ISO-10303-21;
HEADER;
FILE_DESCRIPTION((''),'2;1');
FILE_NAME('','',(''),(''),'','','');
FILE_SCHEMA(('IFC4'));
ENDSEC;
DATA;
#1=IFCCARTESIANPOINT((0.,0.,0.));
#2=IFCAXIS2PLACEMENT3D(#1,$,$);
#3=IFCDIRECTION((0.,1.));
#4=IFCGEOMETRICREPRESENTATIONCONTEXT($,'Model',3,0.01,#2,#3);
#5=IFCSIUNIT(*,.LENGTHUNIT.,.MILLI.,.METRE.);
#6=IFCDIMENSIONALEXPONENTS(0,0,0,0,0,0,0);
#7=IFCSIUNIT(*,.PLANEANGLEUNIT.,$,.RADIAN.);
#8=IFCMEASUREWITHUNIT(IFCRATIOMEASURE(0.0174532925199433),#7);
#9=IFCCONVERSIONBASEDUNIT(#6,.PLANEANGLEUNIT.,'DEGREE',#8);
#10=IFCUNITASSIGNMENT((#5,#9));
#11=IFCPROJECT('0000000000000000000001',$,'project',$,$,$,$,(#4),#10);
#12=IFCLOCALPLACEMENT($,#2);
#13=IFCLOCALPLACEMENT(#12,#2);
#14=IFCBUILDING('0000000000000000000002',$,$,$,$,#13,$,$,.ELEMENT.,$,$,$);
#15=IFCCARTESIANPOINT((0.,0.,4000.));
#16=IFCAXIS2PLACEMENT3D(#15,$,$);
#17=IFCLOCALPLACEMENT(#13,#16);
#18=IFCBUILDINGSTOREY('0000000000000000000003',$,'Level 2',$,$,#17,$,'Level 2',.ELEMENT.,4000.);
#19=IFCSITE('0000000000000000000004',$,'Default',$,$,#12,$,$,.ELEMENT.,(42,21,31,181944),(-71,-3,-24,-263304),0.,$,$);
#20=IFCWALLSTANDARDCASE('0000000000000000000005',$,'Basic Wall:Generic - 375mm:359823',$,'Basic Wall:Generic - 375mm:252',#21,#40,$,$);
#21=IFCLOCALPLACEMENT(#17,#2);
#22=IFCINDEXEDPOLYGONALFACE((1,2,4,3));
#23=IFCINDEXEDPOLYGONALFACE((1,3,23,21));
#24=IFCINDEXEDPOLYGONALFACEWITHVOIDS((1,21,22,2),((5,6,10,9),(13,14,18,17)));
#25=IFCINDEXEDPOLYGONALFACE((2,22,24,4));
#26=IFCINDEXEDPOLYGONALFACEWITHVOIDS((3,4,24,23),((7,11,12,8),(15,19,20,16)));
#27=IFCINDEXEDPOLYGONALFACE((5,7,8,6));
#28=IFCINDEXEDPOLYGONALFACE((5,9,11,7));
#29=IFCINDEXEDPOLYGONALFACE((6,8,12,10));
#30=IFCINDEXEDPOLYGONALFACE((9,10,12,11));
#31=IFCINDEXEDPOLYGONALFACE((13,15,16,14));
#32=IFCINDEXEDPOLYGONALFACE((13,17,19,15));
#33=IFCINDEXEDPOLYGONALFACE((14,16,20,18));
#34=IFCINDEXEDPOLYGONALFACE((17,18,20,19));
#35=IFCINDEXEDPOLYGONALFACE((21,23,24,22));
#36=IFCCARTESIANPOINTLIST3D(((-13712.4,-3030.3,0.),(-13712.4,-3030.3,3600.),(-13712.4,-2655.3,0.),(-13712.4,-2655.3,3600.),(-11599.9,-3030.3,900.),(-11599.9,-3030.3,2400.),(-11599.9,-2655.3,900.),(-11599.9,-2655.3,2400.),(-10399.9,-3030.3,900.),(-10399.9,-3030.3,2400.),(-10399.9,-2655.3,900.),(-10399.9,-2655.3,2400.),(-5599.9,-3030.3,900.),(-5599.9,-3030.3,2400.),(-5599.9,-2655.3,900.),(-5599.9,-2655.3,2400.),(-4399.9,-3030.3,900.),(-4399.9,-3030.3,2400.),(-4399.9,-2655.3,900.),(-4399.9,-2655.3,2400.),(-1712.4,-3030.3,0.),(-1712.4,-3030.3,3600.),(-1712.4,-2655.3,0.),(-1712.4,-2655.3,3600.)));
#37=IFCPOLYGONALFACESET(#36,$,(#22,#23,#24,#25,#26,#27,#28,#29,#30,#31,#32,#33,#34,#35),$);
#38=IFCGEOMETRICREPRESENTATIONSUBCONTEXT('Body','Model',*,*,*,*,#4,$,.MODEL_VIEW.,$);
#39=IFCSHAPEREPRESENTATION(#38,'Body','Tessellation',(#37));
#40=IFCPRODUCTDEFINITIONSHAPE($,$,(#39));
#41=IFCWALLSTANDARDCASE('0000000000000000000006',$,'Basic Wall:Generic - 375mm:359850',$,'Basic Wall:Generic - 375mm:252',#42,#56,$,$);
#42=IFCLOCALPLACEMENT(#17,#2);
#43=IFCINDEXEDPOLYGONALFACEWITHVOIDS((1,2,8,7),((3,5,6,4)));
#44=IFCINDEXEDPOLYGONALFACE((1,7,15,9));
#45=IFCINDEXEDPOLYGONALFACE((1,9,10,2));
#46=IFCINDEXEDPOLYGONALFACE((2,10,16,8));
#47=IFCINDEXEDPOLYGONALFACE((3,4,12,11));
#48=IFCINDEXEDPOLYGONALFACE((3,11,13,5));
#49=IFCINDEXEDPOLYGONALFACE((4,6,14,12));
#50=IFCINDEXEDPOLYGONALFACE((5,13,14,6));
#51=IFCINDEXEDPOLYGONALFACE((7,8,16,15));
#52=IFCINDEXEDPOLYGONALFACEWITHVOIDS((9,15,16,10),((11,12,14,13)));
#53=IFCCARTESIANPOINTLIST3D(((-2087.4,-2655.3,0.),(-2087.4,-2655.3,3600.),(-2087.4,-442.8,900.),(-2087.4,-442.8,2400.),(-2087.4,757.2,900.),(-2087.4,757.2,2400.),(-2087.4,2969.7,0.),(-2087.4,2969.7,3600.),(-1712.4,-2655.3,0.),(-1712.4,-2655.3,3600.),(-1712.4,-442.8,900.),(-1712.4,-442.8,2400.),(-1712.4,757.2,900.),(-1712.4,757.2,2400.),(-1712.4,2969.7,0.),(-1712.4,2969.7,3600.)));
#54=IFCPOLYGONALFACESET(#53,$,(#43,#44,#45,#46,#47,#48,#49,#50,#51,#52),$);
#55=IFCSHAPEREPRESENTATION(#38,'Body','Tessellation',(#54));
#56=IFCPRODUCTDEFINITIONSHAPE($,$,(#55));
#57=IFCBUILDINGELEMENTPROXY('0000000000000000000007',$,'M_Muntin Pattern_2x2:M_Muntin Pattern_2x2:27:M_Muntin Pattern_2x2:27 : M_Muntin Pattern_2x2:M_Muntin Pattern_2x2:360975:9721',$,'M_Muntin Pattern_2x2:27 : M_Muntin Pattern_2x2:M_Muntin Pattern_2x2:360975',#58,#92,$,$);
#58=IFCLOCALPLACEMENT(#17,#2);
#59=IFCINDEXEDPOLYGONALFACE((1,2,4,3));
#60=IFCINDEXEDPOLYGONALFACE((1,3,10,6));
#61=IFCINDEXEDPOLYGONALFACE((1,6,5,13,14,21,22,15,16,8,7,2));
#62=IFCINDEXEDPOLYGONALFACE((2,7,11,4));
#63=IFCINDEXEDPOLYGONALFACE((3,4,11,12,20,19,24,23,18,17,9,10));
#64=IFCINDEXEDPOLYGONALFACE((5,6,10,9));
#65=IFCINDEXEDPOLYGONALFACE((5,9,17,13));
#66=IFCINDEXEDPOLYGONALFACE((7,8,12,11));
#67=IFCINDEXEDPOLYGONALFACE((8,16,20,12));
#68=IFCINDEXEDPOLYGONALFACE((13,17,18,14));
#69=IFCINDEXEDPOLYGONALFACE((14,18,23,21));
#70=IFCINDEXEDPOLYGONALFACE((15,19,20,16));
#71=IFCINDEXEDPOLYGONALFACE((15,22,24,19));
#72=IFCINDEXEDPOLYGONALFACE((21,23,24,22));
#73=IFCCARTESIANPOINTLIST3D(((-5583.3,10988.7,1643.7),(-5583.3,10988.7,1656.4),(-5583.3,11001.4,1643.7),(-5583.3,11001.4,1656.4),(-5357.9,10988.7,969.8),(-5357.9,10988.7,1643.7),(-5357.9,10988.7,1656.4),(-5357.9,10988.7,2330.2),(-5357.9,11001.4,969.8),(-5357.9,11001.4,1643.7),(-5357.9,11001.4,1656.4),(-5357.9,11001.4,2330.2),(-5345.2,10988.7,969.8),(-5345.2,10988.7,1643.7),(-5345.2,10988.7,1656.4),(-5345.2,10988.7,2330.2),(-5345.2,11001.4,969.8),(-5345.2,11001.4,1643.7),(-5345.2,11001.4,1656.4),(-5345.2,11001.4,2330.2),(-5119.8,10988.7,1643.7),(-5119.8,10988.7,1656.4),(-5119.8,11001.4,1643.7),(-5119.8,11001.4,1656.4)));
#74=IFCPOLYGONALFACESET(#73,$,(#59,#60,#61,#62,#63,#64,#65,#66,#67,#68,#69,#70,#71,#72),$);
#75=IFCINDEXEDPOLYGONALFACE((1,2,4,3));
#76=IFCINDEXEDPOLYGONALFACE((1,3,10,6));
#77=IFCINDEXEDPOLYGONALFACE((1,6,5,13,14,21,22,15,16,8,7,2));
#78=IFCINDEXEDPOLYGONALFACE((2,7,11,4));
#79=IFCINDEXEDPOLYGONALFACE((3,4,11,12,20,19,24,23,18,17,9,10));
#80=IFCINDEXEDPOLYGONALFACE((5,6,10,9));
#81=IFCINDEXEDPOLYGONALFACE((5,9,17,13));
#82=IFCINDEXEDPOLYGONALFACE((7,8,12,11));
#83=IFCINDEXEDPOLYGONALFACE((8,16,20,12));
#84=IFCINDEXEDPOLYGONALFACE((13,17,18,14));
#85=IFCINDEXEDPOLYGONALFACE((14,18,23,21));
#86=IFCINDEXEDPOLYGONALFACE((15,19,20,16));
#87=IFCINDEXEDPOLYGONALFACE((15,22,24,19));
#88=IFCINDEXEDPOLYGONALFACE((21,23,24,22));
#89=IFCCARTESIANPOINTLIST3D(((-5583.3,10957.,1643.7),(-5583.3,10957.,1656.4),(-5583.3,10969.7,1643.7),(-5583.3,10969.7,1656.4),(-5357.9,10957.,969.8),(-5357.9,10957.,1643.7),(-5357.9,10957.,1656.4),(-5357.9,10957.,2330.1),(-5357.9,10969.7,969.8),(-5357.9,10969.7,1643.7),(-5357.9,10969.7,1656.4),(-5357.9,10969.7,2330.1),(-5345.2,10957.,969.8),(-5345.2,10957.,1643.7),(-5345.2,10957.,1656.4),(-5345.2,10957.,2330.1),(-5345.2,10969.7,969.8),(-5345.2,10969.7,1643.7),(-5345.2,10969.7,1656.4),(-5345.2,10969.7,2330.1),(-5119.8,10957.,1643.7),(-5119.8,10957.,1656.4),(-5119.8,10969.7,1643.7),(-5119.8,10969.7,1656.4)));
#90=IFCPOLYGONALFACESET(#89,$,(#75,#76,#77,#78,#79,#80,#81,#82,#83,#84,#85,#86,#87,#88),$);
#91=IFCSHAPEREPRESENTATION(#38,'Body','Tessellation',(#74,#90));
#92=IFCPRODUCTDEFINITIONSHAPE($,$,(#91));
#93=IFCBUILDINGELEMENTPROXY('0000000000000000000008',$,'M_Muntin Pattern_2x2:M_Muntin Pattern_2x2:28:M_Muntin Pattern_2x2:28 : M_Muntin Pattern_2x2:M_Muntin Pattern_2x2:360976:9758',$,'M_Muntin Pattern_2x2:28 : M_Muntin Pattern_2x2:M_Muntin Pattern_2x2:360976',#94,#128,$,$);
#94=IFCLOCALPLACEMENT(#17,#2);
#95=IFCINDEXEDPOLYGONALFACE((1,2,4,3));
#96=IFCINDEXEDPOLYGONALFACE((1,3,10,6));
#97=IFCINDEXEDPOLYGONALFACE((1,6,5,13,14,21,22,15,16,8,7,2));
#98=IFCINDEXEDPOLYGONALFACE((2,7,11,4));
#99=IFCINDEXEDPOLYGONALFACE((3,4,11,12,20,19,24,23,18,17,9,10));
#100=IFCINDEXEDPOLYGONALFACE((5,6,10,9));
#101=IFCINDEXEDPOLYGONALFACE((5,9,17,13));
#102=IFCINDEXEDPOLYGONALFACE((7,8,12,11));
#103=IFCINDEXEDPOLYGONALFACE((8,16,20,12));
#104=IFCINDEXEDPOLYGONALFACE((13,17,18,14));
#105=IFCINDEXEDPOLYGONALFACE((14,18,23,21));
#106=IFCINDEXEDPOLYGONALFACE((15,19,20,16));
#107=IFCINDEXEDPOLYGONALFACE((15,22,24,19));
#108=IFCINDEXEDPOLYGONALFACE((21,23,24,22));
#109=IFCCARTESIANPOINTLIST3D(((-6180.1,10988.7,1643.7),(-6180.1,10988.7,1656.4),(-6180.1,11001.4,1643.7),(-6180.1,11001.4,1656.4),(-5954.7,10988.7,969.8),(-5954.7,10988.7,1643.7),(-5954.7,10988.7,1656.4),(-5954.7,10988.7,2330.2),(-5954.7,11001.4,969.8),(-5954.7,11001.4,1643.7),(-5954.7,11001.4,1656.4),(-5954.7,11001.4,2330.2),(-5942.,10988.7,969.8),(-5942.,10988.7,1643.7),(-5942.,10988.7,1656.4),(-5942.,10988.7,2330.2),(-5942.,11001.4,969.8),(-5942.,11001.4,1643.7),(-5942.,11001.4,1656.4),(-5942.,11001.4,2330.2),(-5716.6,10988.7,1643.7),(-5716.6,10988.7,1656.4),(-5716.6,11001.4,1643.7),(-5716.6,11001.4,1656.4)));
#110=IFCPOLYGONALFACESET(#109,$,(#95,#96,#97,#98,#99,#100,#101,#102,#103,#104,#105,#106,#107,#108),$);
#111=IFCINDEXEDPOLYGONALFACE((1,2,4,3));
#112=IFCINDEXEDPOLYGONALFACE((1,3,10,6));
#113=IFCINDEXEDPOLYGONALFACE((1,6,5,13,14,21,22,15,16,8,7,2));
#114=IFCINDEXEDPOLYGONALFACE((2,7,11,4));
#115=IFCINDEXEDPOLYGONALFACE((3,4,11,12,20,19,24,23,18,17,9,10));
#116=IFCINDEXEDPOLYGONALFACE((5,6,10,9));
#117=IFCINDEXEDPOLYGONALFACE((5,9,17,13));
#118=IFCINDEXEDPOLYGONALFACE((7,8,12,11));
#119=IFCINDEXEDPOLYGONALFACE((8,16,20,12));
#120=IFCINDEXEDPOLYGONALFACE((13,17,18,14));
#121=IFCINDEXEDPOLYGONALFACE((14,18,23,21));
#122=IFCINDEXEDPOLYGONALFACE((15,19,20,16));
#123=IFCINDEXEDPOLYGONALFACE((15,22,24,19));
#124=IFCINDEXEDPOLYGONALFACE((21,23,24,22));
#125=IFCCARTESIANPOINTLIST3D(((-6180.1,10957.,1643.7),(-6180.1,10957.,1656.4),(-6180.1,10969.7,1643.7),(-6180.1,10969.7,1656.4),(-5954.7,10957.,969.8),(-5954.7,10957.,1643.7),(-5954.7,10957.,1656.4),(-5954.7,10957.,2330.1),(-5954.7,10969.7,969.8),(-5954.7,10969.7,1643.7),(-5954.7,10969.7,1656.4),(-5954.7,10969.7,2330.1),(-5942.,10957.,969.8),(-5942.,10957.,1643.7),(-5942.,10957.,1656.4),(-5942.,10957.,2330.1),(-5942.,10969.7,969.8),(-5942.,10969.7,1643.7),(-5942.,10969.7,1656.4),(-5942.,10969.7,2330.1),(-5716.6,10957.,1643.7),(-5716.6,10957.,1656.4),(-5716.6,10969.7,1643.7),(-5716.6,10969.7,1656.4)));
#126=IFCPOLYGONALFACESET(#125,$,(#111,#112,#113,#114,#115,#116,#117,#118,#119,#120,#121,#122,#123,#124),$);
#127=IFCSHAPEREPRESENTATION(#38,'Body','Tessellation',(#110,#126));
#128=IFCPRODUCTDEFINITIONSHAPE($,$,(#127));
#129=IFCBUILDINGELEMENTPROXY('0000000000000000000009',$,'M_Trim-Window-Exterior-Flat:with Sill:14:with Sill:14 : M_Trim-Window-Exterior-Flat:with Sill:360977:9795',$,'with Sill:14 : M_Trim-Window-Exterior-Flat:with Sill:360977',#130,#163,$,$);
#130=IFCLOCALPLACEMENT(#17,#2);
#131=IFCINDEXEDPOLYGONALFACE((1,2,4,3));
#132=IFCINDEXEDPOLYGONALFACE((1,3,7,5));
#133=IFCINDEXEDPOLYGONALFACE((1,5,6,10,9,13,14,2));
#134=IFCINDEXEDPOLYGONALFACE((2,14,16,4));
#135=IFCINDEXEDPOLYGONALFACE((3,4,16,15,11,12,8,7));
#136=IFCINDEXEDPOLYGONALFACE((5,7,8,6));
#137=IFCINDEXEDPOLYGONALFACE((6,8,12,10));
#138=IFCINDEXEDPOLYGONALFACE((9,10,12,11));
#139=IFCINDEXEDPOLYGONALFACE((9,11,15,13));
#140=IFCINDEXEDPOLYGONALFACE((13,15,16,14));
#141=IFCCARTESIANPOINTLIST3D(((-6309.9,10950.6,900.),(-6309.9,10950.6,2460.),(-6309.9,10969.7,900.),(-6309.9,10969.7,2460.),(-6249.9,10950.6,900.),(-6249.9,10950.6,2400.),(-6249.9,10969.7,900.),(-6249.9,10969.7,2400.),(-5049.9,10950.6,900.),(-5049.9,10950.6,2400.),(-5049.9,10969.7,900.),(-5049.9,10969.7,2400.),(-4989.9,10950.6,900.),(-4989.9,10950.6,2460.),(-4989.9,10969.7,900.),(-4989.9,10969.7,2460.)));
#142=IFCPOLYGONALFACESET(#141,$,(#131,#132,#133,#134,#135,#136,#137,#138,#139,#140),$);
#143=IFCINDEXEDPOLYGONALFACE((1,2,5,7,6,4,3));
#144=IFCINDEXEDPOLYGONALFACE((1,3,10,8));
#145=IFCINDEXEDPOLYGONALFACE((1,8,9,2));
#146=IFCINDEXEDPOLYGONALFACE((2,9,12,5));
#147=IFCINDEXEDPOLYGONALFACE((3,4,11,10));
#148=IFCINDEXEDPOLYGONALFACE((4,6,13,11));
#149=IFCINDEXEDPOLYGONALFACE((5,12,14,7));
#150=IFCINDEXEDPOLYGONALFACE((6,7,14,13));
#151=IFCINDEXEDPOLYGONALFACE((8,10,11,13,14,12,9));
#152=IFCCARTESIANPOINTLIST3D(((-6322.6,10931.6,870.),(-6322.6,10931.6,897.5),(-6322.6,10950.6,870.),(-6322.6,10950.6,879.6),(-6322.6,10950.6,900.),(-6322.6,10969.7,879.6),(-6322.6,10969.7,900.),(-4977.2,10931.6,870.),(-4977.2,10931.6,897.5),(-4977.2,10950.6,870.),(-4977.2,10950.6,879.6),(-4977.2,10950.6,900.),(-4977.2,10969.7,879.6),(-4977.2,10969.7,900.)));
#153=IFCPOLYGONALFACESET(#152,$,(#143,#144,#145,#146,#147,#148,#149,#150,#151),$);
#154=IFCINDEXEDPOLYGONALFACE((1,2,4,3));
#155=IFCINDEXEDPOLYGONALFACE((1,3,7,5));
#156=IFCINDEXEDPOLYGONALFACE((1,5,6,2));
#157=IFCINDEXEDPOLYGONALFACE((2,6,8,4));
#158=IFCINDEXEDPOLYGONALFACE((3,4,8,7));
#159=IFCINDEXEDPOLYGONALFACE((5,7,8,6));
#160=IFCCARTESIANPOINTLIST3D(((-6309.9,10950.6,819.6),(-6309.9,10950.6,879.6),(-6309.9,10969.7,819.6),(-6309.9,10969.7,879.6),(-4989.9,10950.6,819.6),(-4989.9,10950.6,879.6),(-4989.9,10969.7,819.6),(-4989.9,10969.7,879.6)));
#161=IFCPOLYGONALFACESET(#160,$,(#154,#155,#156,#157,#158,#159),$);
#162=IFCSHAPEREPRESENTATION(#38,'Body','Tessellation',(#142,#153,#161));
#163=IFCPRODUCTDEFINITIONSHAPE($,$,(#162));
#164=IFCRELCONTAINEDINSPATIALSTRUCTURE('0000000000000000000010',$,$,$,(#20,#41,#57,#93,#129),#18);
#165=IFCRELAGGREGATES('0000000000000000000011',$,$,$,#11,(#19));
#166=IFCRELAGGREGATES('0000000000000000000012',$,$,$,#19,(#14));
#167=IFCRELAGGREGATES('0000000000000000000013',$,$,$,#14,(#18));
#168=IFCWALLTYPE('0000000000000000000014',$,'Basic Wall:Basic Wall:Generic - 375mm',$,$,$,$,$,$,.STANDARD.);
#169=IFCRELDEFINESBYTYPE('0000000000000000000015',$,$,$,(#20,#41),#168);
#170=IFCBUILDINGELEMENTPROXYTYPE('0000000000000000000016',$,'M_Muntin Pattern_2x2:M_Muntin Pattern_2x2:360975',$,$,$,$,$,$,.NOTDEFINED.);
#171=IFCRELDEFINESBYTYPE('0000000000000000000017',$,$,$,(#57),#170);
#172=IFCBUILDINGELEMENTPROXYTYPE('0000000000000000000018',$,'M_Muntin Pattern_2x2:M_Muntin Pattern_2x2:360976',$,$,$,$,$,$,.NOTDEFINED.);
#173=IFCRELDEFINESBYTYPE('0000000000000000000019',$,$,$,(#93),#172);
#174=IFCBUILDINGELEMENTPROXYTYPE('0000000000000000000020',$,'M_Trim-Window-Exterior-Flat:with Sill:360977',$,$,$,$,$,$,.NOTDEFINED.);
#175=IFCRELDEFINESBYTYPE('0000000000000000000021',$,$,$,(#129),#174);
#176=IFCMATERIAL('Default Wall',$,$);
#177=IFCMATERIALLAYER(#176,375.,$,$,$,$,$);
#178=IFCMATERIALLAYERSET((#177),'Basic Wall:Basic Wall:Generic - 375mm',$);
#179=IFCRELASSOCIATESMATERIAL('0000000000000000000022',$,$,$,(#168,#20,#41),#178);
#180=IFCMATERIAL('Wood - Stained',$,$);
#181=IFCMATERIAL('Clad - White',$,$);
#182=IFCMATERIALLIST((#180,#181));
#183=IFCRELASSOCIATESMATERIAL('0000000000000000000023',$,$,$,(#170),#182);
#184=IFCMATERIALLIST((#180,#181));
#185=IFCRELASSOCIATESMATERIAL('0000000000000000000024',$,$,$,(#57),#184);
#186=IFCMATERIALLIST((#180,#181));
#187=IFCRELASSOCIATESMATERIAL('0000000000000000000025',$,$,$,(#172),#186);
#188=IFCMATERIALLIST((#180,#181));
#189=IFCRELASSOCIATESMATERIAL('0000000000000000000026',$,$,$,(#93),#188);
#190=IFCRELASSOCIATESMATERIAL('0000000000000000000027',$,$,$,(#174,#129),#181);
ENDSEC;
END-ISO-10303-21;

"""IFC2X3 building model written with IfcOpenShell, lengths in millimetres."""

from ifc_helpers import new_model, entity, si_unit, converted_unit, direction, frame, frame_2d, origin, place, context, subcontext, project, spatial, polyline, rectangle, outline, extrude, source, transform, mapped, material, material_list, layer, layer_set, layer_usage, type_object, type_shapes, element, save


model = new_model("IFC2X3")

# Units and contexts
model_context = context("Model", 3, precision=0.01, world=origin(), true_north=direction((0.0, 1.0)))
body_context = subcontext(model_context, "Body", "Model", "MODEL_VIEW")
ifc_project = project(units=[si_unit("LENGTHUNIT", "METRE", prefix="MILLI"), converted_unit("PLANEANGLEUNIT", "DEGREE", entity("IfcRatioMeasure", 0.0174532925199433), si_unit("PLANEANGLEUNIT", "RADIAN"), dimensions=[0, 0, 0, 0, 0, 0, 0])], contexts=[model_context])

# Site, building, storey
site_placement = place(None, origin())
site = spatial("IfcSite", under=ifc_project, at=site_placement, Name="Default", CompositionType="ELEMENT", RefLatitude=(42, 21, 31, 181944), RefLongitude=(-71, -3, -24, -263304), RefElevation=0.0)
building_placement = place(site_placement, origin())
building = spatial("IfcBuilding", under=site, at=building_placement, CompositionType="ELEMENT")
storey_placement = place(building_placement, frame((0.0, 0.0, 4000.0)))
storey = spatial("IfcBuildingStorey", under=building, at=storey_placement, Name="Level 2", LongName="Level 2", CompositionType="ELEMENT", Elevation=4000.0)

# Wall, openings
ifc_material_1 = material(Name="Default Wall")
ifc_layer_1 = layer(ifc_material_1, 375.0)
ifc_layer_set_1 = layer_set([ifc_layer_1], Name="Basic Wall:Basic Wall:Generic - 375mm")
ifc_layer_usage_1 = layer_usage(ifc_layer_set_1, "AXIS2", "NEGATIVE", 187.5)
wall_type = type_object("IfcWallType", Name="Basic Wall:Basic Wall:Generic - 375mm", PredefinedType="STANDARD", material=ifc_layer_set_1)
wall_1_placement = place(storey_placement, frame((-13712.4, -2842.8, 0.0)))
wall_1 = element("IfcWallStandardCase", 1, at=wall_1_placement, inside=storey, type_object=wall_type, material=ifc_layer_usage_1, Name="Basic Wall:Generic - 375mm:359823", ObjectType="Basic Wall:Generic - 375mm:252", context=body_context, shape_type="SweptSolid", body=[
    extrude(rectangle(XDim=12000.0, YDim=375.0, at=frame_2d((6000.0, 0.0), x_axis=(-1.0, 0.0))), origin(), (0.0, 0.0, 1.0), 3600.0),
])
opening_1_placement = place(wall_1_placement, frame((13712.4, 2842.8, 0.0)))
element("IfcOpeningElement", 2, at=opening_1_placement, cuts=wall_1, ObjectType="Opening", context=body_context, shape_type="SweptSolid", body=[
    extrude(rectangle(XDim=1500.0, YDim=1200.0, at=frame_2d((0.0, 0.0), x_axis=(0.0, 1.0))), frame((-10999.9, -3034.1, 1650.0), z_axis=(0.0, 1.0, 0.0), x_axis=(-1.0, 0.0, 0.0)), (0.0, 0.0, 1.0), 382.5),
])
opening_2_placement = place(wall_1_placement, frame((13712.4, 2842.8, 0.0)))
element("IfcOpeningElement", 3, at=opening_2_placement, cuts=wall_1, ObjectType="Opening", context=body_context, shape_type="SweptSolid", body=[
    extrude(rectangle(XDim=1500.0, YDim=1200.0, at=frame_2d((0.0, 0.0), x_axis=(0.0, 1.0))), frame((-4999.9, -3034.1, 1650.0), z_axis=(0.0, 1.0, 0.0), x_axis=(-1.0, 0.0, 0.0)), (0.0, 0.0, 1.0), 382.5),
])

# Wall, opening
ifc_layer_usage_2 = layer_usage(ifc_layer_set_1, "AXIS2", "NEGATIVE", 187.5)
wall_2_placement = place(storey_placement, frame((-1899.9, -2655.3, 0.0), z_axis=(0.0, 0.0, 1.0), x_axis=(0.0, 1.0, 0.0)))
wall_2 = element("IfcWallStandardCase", 4, at=wall_2_placement, inside=storey, type_object=wall_type, material=ifc_layer_usage_2, Name="Basic Wall:Generic - 375mm:359850", ObjectType="Basic Wall:Generic - 375mm:252", context=body_context, shape_type="SweptSolid", body=[
    extrude(rectangle(XDim=5625.0, YDim=375.0, at=frame_2d((2812.5, 0.0), x_axis=(-1.0, 0.0))), origin(), (0.0, 0.0, 1.0), 3600.0),
])
opening_3_placement = place(wall_2_placement, frame((2655.3, -1899.9, 0.0), z_axis=(0.0, 0.0, 1.0), x_axis=(0.0, -1.0, 0.0)))
element("IfcOpeningElement", 5, at=opening_3_placement, cuts=wall_2, ObjectType="Opening", context=body_context, shape_type="SweptSolid", body=[
    extrude(rectangle(XDim=1500.0, YDim=1200.0, at=frame_2d((0.0, 0.0), x_axis=(0.0, 1.0))), frame((-1708.7, 157.2, 1650.0), z_axis=(-1.0, 0.0, 0.0), x_axis=(0.0, -1.0, 0.0)), (0.0, 0.0, 1.0), 382.5),
])

# Building element proxies
ifc_material_2 = material(Name="Wood - Stained")
ifc_material_3 = material(Name="Clad - White")
ifc_material_list_1 = material_list([ifc_material_2, ifc_material_3])
ifc_material_list_2 = material_list([ifc_material_2, ifc_material_3])
building_element_proxy_type_1 = type_object("IfcBuildingElementProxyType", Name="M_Muntin Pattern_2x2:M_Muntin Pattern_2x2:360975", PredefinedType="NOTDEFINED", material=ifc_material_list_2)
shared_shape_1 = source(origin(), body_context, "Body", "SweptSolid", [
    extrude(outline(polyline([(-680.2, 6.4), (-680.2, -6.3), (-6.4, -6.3), (-6.4, -231.7), (6.3, -231.7), (6.3, -6.3), (680.2, -6.3), (680.2, 6.4), (6.3, 6.4), (6.3, 231.7), (-6.4, 231.7), (-6.4, 6.4), (-680.2, 6.4)])), frame((-5351.5, 10988.7, 5650.0), z_axis=(0.0, -1.0, 0.0), x_axis=(0.0, 0.0, -1.0)), (0.0, 0.0, -1.0), 12.7),
    extrude(outline(polyline([(-680.1, 6.4), (-680.1, -6.3), (-6.4, -6.3), (-6.4, -231.7), (6.3, -231.7), (6.3, -6.3), (680.2, -6.3), (680.2, 6.4), (6.3, 6.4), (6.3, 231.7), (-6.4, 231.7), (-6.4, 6.4), (-680.1, 6.4)])), frame((-5351.5, 10957.0, 5650.0), z_axis=(0.0, -1.0, 0.0), x_axis=(0.0, 0.0, -1.0)), (0.0, 0.0, -1.0), 12.7),
])
type_shapes(building_element_proxy_type_1, [shared_shape_1])
proxy_1_placement = place(storey_placement, frame((0.0, 0.0, -4000.0)))
element("IfcBuildingElementProxy", 6, at=proxy_1_placement, inside=storey, type_object=building_element_proxy_type_1, material=ifc_material_list_1, Name="M_Muntin Pattern_2x2:M_Muntin Pattern_2x2:27:M_Muntin Pattern_2x2:27 : M_Muntin Pattern_2x2:M_Muntin Pattern_2x2:360975:9721", ObjectType="M_Muntin Pattern_2x2:27 : M_Muntin Pattern_2x2:M_Muntin Pattern_2x2:360975", context=body_context, shape_type="MappedRepresentation", body=[
    mapped(shared_shape_1, transform((0.0, 0.0, 0.0), scale=1.0)),
])
ifc_material_list_3 = material_list([ifc_material_2, ifc_material_3])
ifc_material_list_4 = material_list([ifc_material_2, ifc_material_3])
building_element_proxy_type_2 = type_object("IfcBuildingElementProxyType", Name="M_Muntin Pattern_2x2:M_Muntin Pattern_2x2:360976", PredefinedType="NOTDEFINED", material=ifc_material_list_4)
shared_shape_2 = source(origin(), body_context, "Body", "SweptSolid", [
    extrude(outline(polyline([(-6.4, -680.1), (6.3, -680.1), (6.3, -6.4), (231.7, -6.4), (231.7, 6.3), (6.3, 6.3), (6.3, 680.2), (-6.4, 680.2), (-6.4, 6.3), (-231.7, 6.3), (-231.7, -6.4), (-6.4, -6.4), (-6.4, -680.1)])), frame((-5948.4, 10988.7, 5650.0), z_axis=(0.0, 1.0, 0.0), x_axis=(1.0, 0.0, 0.0)), (0.0, 0.0, 1.0), 12.7),
    extrude(outline(polyline([(-6.4, -680.1), (6.3, -680.1), (6.3, -6.4), (231.7, -6.4), (231.7, 6.3), (6.3, 6.3), (6.3, 680.2), (-6.4, 680.2), (-6.4, 6.3), (-231.7, 6.3), (-231.7, -6.4), (-6.4, -6.4), (-6.4, -680.1)])), frame((-5948.4, 10957.0, 5650.0), z_axis=(0.0, 1.0, 0.0), x_axis=(1.0, 0.0, 0.0)), (0.0, 0.0, 1.0), 12.7),
])
type_shapes(building_element_proxy_type_2, [shared_shape_2])
proxy_2_placement = place(storey_placement, frame((0.0, 0.0, -4000.0)))
element("IfcBuildingElementProxy", 7, at=proxy_2_placement, inside=storey, type_object=building_element_proxy_type_2, material=ifc_material_list_3, Name="M_Muntin Pattern_2x2:M_Muntin Pattern_2x2:28:M_Muntin Pattern_2x2:28 : M_Muntin Pattern_2x2:M_Muntin Pattern_2x2:360976:9758", ObjectType="M_Muntin Pattern_2x2:28 : M_Muntin Pattern_2x2:M_Muntin Pattern_2x2:360976", context=body_context, shape_type="MappedRepresentation", body=[
    mapped(shared_shape_2, transform((0.0, 0.0, 0.0), scale=1.0)),
])
building_element_proxy_type_3 = type_object("IfcBuildingElementProxyType", Name="M_Trim-Window-Exterior-Flat:with Sill:360977", PredefinedType="NOTDEFINED", material=ifc_material_3)
shared_shape_3 = source(origin(), body_context, "Body", "SweptSolid", [
    extrude(outline(polyline([(-765.0, -660.0), (795.0, -660.0), (795.0, 660.0), (-765.0, 660.0), (-765.0, 600.0), (735.0, 600.0), (735.0, -600.0), (-765.0, -600.0), (-765.0, -660.0)])), frame((-5649.9, 10950.6, 5665.0), z_axis=(0.0, 1.0, 0.0), x_axis=(0.0, 0.0, 1.0)), (0.0, 0.0, 1.0), 19.1),
    extrude(outline(polyline([(-15.2, 0.0), (-15.2, -19.0), (12.3, -19.0), (14.8, 0.0), (14.8, 19.0), (-5.7, 19.0), (-5.7, 0.0), (-15.2, 0.0)])), frame((-6322.6, 10950.6, 4885.2), z_axis=(-1.0, 0.0, 0.0), x_axis=(0.0, 0.0, 1.0)), (0.0, 0.0, -1.0), 1345.4),
    extrude(rectangle(XDim=19.1, YDim=1320.0, at=frame_2d((0.0, 0.0), x_axis=(1.0, 0.0))), frame((-5649.9, 10960.1, 4819.6), z_axis=(0.0, 0.0, 1.0), x_axis=(0.0, 1.0, 0.0)), (0.0, 0.0, 1.0), 60.0),
])
type_shapes(building_element_proxy_type_3, [shared_shape_3])
proxy_3_placement = place(storey_placement, frame((0.0, 0.0, -4000.0)))
element("IfcBuildingElementProxy", 8, at=proxy_3_placement, inside=storey, type_object=building_element_proxy_type_3, material=ifc_material_3, Name="M_Trim-Window-Exterior-Flat:with Sill:14:with Sill:14 : M_Trim-Window-Exterior-Flat:with Sill:360977:9795", ObjectType="with Sill:14 : M_Trim-Window-Exterior-Flat:with Sill:360977", context=body_context, shape_type="MappedRepresentation", body=[
    mapped(shared_shape_3, transform((0.0, 0.0, 0.0), scale=1.0)),
])

save(model, "model.ifc")
